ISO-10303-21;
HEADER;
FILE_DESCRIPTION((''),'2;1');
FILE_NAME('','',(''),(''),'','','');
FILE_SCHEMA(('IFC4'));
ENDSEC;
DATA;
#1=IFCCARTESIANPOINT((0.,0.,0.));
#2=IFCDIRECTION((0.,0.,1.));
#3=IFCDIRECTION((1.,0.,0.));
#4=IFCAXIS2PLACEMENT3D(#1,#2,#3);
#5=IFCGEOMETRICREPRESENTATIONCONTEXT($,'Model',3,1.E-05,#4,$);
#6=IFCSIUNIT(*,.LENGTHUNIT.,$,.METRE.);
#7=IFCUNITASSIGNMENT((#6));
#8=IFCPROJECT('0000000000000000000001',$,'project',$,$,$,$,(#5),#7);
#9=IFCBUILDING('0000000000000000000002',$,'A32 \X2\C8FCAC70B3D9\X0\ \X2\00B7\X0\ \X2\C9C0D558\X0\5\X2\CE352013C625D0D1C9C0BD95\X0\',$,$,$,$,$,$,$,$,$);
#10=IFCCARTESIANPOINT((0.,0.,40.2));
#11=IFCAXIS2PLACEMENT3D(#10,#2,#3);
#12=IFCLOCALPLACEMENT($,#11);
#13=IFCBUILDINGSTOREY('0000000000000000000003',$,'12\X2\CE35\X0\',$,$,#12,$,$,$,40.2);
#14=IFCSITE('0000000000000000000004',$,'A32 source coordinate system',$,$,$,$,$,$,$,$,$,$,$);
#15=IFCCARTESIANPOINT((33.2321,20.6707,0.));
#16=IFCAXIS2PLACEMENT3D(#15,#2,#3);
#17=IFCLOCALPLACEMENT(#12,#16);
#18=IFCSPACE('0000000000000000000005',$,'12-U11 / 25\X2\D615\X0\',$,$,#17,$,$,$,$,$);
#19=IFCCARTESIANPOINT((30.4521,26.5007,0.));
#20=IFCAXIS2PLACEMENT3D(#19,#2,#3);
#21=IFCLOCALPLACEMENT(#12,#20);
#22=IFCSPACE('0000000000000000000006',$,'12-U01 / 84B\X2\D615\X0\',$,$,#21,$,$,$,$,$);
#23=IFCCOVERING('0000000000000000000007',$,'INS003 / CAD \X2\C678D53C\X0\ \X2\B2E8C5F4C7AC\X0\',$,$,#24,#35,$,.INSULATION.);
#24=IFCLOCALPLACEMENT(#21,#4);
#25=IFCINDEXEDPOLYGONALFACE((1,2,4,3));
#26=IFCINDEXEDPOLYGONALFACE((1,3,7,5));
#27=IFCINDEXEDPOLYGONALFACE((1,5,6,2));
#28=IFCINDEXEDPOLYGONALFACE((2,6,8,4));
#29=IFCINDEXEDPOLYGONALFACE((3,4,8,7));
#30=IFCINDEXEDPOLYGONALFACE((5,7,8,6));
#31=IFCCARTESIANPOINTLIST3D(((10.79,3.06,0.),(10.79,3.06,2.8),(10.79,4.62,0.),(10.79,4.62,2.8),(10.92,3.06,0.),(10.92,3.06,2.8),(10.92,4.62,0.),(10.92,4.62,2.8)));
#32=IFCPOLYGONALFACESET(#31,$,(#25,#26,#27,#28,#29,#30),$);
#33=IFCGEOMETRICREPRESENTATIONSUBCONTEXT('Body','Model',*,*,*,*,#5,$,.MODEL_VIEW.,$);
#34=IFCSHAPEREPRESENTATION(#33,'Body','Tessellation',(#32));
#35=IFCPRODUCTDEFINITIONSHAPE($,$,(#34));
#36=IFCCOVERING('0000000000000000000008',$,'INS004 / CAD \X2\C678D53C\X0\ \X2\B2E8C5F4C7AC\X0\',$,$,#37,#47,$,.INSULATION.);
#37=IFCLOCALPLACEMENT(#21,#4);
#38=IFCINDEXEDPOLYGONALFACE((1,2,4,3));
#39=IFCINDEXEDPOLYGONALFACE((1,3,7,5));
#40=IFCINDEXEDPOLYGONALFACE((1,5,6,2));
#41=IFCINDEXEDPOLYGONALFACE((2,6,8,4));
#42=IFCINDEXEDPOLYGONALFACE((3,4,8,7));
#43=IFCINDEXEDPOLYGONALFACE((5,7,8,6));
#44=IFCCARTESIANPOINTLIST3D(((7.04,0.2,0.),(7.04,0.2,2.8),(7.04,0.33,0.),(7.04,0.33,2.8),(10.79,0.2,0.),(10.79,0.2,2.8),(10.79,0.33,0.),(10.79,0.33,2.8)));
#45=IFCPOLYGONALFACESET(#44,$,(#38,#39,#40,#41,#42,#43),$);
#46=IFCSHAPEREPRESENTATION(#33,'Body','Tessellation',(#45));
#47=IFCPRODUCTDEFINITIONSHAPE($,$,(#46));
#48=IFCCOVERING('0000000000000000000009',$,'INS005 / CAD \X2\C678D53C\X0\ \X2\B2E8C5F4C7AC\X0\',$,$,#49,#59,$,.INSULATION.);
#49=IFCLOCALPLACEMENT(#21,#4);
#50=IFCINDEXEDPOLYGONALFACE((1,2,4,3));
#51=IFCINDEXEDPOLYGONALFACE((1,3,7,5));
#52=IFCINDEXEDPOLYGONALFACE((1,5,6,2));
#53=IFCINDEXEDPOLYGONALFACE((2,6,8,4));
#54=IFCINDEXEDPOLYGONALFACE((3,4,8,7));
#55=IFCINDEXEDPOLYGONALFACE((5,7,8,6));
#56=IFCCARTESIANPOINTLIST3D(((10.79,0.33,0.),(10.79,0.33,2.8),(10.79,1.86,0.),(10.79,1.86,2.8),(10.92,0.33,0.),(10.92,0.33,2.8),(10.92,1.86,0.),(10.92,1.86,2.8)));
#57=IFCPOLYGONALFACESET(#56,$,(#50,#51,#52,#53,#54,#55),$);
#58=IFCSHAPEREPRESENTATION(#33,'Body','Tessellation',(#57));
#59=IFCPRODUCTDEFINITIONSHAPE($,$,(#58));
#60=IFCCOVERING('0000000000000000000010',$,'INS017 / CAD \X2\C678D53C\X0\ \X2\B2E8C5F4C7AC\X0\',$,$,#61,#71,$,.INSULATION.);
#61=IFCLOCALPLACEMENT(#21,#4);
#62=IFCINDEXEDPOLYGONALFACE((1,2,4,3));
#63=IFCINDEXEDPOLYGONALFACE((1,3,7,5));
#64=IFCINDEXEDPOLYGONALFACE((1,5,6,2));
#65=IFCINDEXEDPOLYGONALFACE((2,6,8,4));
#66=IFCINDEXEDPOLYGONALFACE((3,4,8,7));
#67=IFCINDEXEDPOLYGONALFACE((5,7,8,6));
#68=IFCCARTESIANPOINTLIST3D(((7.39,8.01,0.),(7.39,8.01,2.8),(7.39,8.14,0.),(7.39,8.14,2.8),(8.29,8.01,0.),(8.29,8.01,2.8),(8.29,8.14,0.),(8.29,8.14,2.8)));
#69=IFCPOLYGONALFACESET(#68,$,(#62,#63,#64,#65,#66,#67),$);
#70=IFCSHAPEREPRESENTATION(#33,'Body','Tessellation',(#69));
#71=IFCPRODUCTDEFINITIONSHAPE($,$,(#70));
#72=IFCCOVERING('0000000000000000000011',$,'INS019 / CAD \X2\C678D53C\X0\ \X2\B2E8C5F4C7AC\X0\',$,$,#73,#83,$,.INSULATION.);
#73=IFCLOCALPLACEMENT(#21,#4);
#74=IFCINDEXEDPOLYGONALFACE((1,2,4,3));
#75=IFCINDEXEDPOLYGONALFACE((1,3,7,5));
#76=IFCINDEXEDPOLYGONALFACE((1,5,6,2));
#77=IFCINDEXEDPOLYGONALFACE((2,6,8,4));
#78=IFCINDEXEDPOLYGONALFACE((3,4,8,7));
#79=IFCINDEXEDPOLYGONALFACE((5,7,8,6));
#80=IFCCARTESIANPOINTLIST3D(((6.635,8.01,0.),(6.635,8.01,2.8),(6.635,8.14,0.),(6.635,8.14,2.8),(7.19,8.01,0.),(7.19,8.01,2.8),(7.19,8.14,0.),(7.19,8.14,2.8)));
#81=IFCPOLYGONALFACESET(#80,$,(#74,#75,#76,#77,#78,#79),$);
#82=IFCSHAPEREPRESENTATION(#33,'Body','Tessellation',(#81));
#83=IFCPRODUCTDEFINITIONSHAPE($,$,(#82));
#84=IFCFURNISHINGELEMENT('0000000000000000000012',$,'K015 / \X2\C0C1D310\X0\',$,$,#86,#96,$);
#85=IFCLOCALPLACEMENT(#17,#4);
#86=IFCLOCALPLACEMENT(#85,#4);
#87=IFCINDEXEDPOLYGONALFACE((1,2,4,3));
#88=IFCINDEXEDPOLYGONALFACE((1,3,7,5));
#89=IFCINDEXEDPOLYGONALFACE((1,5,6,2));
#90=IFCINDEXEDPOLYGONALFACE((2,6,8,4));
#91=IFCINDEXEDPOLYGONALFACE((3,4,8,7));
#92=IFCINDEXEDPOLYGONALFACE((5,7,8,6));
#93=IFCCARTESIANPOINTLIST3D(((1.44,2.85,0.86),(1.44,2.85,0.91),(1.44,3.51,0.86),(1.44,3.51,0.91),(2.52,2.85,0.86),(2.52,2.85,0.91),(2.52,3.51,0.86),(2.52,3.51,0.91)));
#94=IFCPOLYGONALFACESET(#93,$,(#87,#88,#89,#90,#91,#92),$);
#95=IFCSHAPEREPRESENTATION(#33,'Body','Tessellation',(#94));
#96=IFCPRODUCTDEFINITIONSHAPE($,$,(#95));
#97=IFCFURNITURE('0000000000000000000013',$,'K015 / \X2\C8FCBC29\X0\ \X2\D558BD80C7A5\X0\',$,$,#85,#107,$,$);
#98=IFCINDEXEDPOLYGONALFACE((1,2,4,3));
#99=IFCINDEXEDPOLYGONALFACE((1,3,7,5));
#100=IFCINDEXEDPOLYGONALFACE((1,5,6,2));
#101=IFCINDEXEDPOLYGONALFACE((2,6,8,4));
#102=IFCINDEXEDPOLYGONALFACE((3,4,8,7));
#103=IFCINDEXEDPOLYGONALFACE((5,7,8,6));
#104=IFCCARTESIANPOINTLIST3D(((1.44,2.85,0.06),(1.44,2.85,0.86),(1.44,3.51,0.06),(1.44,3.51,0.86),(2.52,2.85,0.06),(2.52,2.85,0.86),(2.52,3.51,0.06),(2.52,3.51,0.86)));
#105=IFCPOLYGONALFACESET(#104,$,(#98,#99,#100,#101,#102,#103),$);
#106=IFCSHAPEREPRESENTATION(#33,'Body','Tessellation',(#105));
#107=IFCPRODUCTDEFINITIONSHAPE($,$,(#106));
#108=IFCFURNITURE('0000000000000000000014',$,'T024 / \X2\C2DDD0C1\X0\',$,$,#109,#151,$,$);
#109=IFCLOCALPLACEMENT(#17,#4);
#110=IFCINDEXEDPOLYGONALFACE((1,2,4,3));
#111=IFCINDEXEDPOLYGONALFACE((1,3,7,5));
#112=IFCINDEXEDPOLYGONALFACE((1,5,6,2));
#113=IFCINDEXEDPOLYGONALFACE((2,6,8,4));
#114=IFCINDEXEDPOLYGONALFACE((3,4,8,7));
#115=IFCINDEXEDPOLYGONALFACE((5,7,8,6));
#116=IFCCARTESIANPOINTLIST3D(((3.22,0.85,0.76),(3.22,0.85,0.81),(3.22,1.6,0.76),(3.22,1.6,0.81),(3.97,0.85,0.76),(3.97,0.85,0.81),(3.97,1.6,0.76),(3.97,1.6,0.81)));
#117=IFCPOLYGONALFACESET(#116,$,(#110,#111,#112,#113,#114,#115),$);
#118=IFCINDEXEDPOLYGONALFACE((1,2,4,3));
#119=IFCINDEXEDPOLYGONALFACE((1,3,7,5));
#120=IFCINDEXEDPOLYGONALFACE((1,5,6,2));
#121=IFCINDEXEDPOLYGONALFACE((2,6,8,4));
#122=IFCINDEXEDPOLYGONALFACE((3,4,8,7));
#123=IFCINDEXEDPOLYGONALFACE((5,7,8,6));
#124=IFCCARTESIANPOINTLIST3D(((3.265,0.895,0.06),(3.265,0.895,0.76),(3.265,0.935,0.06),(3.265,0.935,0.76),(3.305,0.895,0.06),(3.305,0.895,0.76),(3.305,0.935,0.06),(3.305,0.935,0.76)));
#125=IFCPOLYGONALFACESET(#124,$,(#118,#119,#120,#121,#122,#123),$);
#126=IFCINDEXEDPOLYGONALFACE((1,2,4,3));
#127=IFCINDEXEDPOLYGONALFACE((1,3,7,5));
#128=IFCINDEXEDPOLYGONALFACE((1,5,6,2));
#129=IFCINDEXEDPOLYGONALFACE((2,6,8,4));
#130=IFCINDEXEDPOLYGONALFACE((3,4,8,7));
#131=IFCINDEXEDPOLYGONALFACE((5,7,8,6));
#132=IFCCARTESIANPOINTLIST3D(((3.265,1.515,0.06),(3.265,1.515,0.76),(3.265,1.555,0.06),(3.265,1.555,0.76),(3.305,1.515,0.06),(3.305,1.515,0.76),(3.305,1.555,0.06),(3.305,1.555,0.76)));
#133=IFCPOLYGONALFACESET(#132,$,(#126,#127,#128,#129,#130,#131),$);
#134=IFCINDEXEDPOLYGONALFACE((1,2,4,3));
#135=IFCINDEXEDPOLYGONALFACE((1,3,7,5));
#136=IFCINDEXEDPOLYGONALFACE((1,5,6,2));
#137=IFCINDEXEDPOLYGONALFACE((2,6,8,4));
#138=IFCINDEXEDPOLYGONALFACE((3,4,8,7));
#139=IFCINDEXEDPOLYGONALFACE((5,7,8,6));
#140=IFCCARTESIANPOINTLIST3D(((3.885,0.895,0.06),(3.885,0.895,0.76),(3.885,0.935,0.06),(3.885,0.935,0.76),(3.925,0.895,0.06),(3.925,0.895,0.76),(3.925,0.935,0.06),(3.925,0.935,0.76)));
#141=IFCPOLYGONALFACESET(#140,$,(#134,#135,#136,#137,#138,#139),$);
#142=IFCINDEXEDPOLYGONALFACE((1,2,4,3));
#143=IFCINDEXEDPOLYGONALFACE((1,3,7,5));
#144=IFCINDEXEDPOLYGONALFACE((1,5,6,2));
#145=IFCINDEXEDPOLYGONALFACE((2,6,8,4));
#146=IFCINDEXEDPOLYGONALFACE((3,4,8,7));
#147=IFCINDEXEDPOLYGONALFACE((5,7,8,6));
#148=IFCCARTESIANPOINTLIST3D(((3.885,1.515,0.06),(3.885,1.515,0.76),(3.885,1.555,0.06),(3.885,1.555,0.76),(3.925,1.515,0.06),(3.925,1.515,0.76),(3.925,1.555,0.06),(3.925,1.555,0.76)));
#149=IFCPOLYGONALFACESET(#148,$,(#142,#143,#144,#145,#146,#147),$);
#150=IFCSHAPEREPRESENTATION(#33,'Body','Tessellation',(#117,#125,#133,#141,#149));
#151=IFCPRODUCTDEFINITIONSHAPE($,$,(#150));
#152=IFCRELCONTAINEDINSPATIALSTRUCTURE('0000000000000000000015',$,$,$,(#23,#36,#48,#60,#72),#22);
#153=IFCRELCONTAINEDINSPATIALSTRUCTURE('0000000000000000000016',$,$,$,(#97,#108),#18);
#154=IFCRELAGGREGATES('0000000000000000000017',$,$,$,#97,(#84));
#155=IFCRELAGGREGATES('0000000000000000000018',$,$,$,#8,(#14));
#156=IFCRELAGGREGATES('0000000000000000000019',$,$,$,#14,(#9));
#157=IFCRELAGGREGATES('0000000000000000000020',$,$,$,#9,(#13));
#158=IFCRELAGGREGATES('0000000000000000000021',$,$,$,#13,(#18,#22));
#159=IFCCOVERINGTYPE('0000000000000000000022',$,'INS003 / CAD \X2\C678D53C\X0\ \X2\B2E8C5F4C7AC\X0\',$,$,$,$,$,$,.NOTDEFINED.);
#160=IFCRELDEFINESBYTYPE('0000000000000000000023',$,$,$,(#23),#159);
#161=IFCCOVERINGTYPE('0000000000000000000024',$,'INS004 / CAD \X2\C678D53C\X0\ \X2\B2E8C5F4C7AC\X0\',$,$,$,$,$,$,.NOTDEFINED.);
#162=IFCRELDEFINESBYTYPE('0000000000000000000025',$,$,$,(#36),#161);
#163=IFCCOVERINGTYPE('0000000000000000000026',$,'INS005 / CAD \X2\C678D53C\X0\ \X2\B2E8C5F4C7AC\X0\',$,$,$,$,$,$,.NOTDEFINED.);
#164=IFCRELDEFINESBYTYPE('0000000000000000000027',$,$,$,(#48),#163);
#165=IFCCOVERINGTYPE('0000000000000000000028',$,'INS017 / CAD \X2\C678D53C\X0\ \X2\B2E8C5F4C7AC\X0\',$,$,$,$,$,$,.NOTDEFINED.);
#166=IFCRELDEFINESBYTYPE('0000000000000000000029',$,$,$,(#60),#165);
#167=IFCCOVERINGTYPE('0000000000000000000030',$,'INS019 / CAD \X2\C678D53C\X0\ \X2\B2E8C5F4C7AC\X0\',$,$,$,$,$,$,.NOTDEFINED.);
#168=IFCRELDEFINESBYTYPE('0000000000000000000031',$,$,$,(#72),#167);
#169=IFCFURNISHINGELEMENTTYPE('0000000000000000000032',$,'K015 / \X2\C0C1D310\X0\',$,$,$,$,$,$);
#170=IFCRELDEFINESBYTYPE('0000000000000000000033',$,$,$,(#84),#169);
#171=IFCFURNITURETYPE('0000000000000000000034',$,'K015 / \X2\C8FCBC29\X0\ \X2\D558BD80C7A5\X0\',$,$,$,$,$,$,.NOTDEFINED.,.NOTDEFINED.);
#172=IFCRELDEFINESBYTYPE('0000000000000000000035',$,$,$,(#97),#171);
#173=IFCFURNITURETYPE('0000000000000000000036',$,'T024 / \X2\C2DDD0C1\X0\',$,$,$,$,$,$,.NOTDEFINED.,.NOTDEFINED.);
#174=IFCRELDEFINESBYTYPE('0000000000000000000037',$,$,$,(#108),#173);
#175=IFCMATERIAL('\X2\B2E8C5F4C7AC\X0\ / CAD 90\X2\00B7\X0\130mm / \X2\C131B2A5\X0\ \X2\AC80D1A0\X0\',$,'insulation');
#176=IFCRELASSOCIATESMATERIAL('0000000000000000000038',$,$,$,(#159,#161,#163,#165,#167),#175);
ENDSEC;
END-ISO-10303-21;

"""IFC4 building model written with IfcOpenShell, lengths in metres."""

from ifc_helpers import new_model, si_unit, frame, origin, origin_with_axes, place, context, subcontext, project, spatial, polyline, outline, extrude, source, transform, mapped, material, type_object, type_shapes, element, aggregate, save


model = new_model("IFC4")

# Units and contexts
model_context = context("Model", 3, precision=1e-05, world=origin_with_axes())
body_context = subcontext(model_context, "Body", "Model", "MODEL_VIEW")
ifc_project = project(units=[si_unit("LENGTHUNIT", "METRE")], contexts=[model_context])

# Site, building, storey, space
site = spatial("IfcSite", under=ifc_project, Name="A32 source coordinate system")
building = spatial("IfcBuilding", under=site, Name="A32 주거동 · 지하5층–옥탑지붕")
storey_placement = place(None, frame((0.0, 0.0, 40.2), z_axis=(0.0, 0.0, 1.0), x_axis=(1.0, 0.0, 0.0)))
storey = spatial("IfcBuildingStorey", under=building, at=storey_placement, Name="12층", Elevation=40.2)
space_1_placement = place(storey_placement, frame((33.2321, 20.6707, 0.0), z_axis=(0.0, 0.0, 1.0), x_axis=(1.0, 0.0, 0.0)))
space_1 = spatial("IfcSpace", under=storey, at=space_1_placement, Name="12-U11 / 25형")

# Shared definitions
space_2_placement = place(storey_placement, frame((30.4521, 26.5007, 0.0), z_axis=(0.0, 0.0, 1.0), x_axis=(1.0, 0.0, 0.0)))
space_2 = spatial("IfcSpace", under=storey, at=space_2_placement, Name="12-U01 / 84B형")

# Coverings
ifc_material = material(Name="단열재 / CAD 90·130mm / 성능 검토", Category="insulation")
covering_type_1 = type_object("IfcCoveringType", Name="INS003 / CAD 외피 단열재", PredefinedType="NOTDEFINED", material=ifc_material)
shared_shape_1 = source(origin(), body_context, "Body", "SweptSolid", [
    extrude(outline(polyline([(10.79, 3.06), (10.79, 4.62), (10.92, 4.62), (10.92, 3.06), (10.79, 3.06)])), origin(), (0.0, 0.0, 1.0), 2.8),
])
type_shapes(covering_type_1, [shared_shape_1])
covering_1_placement = place(space_2_placement, origin_with_axes())
element("IfcCovering", 1, at=covering_1_placement, inside=space_2, type_object=covering_type_1, Name="INS003 / CAD 외피 단열재", PredefinedType="INSULATION", context=body_context, shape_type="MappedRepresentation", body=[
    mapped(shared_shape_1, transform((0.0, 0.0, 0.0), scale=1.0)),
])
covering_type_2 = type_object("IfcCoveringType", Name="INS004 / CAD 외피 단열재", PredefinedType="NOTDEFINED", material=ifc_material)
shared_shape_2 = source(origin(), body_context, "Body", "SweptSolid", [
    extrude(outline(polyline([(7.04, 0.33), (10.79, 0.33), (10.79, 0.2), (7.04, 0.2), (7.04, 0.33)])), origin(), (0.0, 0.0, 1.0), 2.8),
])
type_shapes(covering_type_2, [shared_shape_2])
covering_2_placement = place(space_2_placement, origin_with_axes())
element("IfcCovering", 2, at=covering_2_placement, inside=space_2, type_object=covering_type_2, Name="INS004 / CAD 외피 단열재", PredefinedType="INSULATION", context=body_context, shape_type="MappedRepresentation", body=[
    mapped(shared_shape_2, transform((0.0, 0.0, 0.0), scale=1.0)),
])
covering_type_3 = type_object("IfcCoveringType", Name="INS005 / CAD 외피 단열재", PredefinedType="NOTDEFINED", material=ifc_material)
shared_shape_3 = source(origin(), body_context, "Body", "SweptSolid", [
    extrude(outline(polyline([(10.79, 0.33), (10.79, 1.86), (10.92, 1.86), (10.92, 0.33), (10.79, 0.33)])), origin(), (0.0, 0.0, 1.0), 2.8),
])
type_shapes(covering_type_3, [shared_shape_3])
covering_3_placement = place(space_2_placement, origin_with_axes())
element("IfcCovering", 3, at=covering_3_placement, inside=space_2, type_object=covering_type_3, Name="INS005 / CAD 외피 단열재", PredefinedType="INSULATION", context=body_context, shape_type="MappedRepresentation", body=[
    mapped(shared_shape_3, transform((0.0, 0.0, 0.0), scale=1.0)),
])
covering_type_4 = type_object("IfcCoveringType", Name="INS017 / CAD 외피 단열재", PredefinedType="NOTDEFINED", material=ifc_material)
shared_shape_4 = source(origin(), body_context, "Body", "SweptSolid", [
    extrude(outline(polyline([(8.29, 8.01), (7.39, 8.01), (7.39, 8.14), (8.29, 8.14), (8.29, 8.01)])), origin(), (0.0, 0.0, 1.0), 2.8),
])
type_shapes(covering_type_4, [shared_shape_4])
covering_4_placement = place(space_2_placement, origin_with_axes())
element("IfcCovering", 4, at=covering_4_placement, inside=space_2, type_object=covering_type_4, Name="INS017 / CAD 외피 단열재", PredefinedType="INSULATION", context=body_context, shape_type="MappedRepresentation", body=[
    mapped(shared_shape_4, transform((0.0, 0.0, 0.0), scale=1.0)),
])
covering_type_5 = type_object("IfcCoveringType", Name="INS019 / CAD 외피 단열재", PredefinedType="NOTDEFINED", material=ifc_material)
shared_shape_5 = source(origin(), body_context, "Body", "SweptSolid", [
    extrude(outline(polyline([(6.635, 8.01), (6.635, 8.14), (7.19, 8.14), (7.19, 8.01), (6.635, 8.01)])), origin(), (0.0, 0.0, 1.0), 2.8),
])
type_shapes(covering_type_5, [shared_shape_5])
covering_5_placement = place(space_2_placement, origin_with_axes())
element("IfcCovering", 5, at=covering_5_placement, inside=space_2, type_object=covering_type_5, Name="INS019 / CAD 외피 단열재", PredefinedType="INSULATION", context=body_context, shape_type="MappedRepresentation", body=[
    mapped(shared_shape_5, transform((0.0, 0.0, 0.0), scale=1.0)),
])

# Furnishing element
furnishing_element_type_1 = type_object("IfcFurnishingElementType", Name="K015 / 상판")
shared_shape_6 = source(origin(), body_context, "Body", "SweptSolid", [
    extrude(outline(polyline([(2.52, 2.85), (1.44, 2.85), (1.44, 3.51), (2.52, 3.51), (2.52, 2.85)])), frame((0.0, 0.0, 0.86)), (0.0, 0.0, 1.0), 0.05),
])
type_shapes(furnishing_element_type_1, [shared_shape_6])
furniture_1_placement = place(space_1_placement, origin_with_axes())
furnishing_1_placement = place(furniture_1_placement, origin_with_axes())
furnishing_1 = element("IfcFurnishingElement", 6, at=furnishing_1_placement, type_object=furnishing_element_type_1, Name="K015 / 상판", context=body_context, shape_type="MappedRepresentation", body=[
    mapped(shared_shape_6, transform((0.0, 0.0, 0.0), scale=1.0)),
])

# Furniture
furniture_type_1 = type_object("IfcFurnitureType", Name="K015 / 주방 하부장", AssemblyPlace="NOTDEFINED", PredefinedType="NOTDEFINED")
shared_shape_7 = source(origin(), body_context, "Body", "SweptSolid", [
    extrude(outline(polyline([(2.52, 3.51), (2.52, 2.85), (1.44, 2.85), (1.44, 3.51), (2.52, 3.51)])), frame((0.0, 0.0, 0.06)), (0.0, 0.0, 1.0), 0.8),
])
type_shapes(furniture_type_1, [shared_shape_7])
furniture_1 = element("IfcFurniture", 7, at=furniture_1_placement, inside=space_1, type_object=furniture_type_1, Name="K015 / 주방 하부장", context=body_context, shape_type="MappedRepresentation", body=[
    mapped(shared_shape_7, transform((0.0, 0.0, 0.0), scale=1.0)),
])
aggregate(furniture_1, [furnishing_1])
furniture_type_2 = type_object("IfcFurnitureType", Name="T024 / 식탁", AssemblyPlace="NOTDEFINED", PredefinedType="NOTDEFINED")
shared_shape_8 = source(origin(), body_context, "Body", "SweptSolid", [
    extrude(outline(polyline([(3.22, 0.85), (3.22, 1.6), (3.97, 1.6), (3.97, 0.85), (3.22, 0.85)])), frame((0.0, 0.0, 0.76)), (0.0, 0.0, 1.0), 0.05),
    extrude(outline(polyline([(3.265, 0.895), (3.265, 0.935), (3.305, 0.935), (3.305, 0.895), (3.265, 0.895)])), frame((0.0, 0.0, 0.06)), (0.0, 0.0, 1.0), 0.7),
    extrude(outline(polyline([(3.265, 1.515), (3.265, 1.555), (3.305, 1.555), (3.305, 1.515), (3.265, 1.515)])), frame((0.0, 0.0, 0.06)), (0.0, 0.0, 1.0), 0.7),
    extrude(outline(polyline([(3.885, 0.895), (3.885, 0.935), (3.925, 0.935), (3.925, 0.895), (3.885, 0.895)])), frame((0.0, 0.0, 0.06)), (0.0, 0.0, 1.0), 0.7),
    extrude(outline(polyline([(3.885, 1.515), (3.885, 1.555), (3.925, 1.555), (3.925, 1.515), (3.885, 1.515)])), frame((0.0, 0.0, 0.06)), (0.0, 0.0, 1.0), 0.7),
])
type_shapes(furniture_type_2, [shared_shape_8])
furniture_2_placement = place(space_1_placement, origin_with_axes())
element("IfcFurniture", 8, at=furniture_2_placement, inside=space_1, type_object=furniture_type_2, Name="T024 / 식탁", context=body_context, shape_type="MappedRepresentation", body=[
    mapped(shared_shape_8, transform((0.0, 0.0, 0.0), scale=1.0)),
])

save(model, "model.ifc")
